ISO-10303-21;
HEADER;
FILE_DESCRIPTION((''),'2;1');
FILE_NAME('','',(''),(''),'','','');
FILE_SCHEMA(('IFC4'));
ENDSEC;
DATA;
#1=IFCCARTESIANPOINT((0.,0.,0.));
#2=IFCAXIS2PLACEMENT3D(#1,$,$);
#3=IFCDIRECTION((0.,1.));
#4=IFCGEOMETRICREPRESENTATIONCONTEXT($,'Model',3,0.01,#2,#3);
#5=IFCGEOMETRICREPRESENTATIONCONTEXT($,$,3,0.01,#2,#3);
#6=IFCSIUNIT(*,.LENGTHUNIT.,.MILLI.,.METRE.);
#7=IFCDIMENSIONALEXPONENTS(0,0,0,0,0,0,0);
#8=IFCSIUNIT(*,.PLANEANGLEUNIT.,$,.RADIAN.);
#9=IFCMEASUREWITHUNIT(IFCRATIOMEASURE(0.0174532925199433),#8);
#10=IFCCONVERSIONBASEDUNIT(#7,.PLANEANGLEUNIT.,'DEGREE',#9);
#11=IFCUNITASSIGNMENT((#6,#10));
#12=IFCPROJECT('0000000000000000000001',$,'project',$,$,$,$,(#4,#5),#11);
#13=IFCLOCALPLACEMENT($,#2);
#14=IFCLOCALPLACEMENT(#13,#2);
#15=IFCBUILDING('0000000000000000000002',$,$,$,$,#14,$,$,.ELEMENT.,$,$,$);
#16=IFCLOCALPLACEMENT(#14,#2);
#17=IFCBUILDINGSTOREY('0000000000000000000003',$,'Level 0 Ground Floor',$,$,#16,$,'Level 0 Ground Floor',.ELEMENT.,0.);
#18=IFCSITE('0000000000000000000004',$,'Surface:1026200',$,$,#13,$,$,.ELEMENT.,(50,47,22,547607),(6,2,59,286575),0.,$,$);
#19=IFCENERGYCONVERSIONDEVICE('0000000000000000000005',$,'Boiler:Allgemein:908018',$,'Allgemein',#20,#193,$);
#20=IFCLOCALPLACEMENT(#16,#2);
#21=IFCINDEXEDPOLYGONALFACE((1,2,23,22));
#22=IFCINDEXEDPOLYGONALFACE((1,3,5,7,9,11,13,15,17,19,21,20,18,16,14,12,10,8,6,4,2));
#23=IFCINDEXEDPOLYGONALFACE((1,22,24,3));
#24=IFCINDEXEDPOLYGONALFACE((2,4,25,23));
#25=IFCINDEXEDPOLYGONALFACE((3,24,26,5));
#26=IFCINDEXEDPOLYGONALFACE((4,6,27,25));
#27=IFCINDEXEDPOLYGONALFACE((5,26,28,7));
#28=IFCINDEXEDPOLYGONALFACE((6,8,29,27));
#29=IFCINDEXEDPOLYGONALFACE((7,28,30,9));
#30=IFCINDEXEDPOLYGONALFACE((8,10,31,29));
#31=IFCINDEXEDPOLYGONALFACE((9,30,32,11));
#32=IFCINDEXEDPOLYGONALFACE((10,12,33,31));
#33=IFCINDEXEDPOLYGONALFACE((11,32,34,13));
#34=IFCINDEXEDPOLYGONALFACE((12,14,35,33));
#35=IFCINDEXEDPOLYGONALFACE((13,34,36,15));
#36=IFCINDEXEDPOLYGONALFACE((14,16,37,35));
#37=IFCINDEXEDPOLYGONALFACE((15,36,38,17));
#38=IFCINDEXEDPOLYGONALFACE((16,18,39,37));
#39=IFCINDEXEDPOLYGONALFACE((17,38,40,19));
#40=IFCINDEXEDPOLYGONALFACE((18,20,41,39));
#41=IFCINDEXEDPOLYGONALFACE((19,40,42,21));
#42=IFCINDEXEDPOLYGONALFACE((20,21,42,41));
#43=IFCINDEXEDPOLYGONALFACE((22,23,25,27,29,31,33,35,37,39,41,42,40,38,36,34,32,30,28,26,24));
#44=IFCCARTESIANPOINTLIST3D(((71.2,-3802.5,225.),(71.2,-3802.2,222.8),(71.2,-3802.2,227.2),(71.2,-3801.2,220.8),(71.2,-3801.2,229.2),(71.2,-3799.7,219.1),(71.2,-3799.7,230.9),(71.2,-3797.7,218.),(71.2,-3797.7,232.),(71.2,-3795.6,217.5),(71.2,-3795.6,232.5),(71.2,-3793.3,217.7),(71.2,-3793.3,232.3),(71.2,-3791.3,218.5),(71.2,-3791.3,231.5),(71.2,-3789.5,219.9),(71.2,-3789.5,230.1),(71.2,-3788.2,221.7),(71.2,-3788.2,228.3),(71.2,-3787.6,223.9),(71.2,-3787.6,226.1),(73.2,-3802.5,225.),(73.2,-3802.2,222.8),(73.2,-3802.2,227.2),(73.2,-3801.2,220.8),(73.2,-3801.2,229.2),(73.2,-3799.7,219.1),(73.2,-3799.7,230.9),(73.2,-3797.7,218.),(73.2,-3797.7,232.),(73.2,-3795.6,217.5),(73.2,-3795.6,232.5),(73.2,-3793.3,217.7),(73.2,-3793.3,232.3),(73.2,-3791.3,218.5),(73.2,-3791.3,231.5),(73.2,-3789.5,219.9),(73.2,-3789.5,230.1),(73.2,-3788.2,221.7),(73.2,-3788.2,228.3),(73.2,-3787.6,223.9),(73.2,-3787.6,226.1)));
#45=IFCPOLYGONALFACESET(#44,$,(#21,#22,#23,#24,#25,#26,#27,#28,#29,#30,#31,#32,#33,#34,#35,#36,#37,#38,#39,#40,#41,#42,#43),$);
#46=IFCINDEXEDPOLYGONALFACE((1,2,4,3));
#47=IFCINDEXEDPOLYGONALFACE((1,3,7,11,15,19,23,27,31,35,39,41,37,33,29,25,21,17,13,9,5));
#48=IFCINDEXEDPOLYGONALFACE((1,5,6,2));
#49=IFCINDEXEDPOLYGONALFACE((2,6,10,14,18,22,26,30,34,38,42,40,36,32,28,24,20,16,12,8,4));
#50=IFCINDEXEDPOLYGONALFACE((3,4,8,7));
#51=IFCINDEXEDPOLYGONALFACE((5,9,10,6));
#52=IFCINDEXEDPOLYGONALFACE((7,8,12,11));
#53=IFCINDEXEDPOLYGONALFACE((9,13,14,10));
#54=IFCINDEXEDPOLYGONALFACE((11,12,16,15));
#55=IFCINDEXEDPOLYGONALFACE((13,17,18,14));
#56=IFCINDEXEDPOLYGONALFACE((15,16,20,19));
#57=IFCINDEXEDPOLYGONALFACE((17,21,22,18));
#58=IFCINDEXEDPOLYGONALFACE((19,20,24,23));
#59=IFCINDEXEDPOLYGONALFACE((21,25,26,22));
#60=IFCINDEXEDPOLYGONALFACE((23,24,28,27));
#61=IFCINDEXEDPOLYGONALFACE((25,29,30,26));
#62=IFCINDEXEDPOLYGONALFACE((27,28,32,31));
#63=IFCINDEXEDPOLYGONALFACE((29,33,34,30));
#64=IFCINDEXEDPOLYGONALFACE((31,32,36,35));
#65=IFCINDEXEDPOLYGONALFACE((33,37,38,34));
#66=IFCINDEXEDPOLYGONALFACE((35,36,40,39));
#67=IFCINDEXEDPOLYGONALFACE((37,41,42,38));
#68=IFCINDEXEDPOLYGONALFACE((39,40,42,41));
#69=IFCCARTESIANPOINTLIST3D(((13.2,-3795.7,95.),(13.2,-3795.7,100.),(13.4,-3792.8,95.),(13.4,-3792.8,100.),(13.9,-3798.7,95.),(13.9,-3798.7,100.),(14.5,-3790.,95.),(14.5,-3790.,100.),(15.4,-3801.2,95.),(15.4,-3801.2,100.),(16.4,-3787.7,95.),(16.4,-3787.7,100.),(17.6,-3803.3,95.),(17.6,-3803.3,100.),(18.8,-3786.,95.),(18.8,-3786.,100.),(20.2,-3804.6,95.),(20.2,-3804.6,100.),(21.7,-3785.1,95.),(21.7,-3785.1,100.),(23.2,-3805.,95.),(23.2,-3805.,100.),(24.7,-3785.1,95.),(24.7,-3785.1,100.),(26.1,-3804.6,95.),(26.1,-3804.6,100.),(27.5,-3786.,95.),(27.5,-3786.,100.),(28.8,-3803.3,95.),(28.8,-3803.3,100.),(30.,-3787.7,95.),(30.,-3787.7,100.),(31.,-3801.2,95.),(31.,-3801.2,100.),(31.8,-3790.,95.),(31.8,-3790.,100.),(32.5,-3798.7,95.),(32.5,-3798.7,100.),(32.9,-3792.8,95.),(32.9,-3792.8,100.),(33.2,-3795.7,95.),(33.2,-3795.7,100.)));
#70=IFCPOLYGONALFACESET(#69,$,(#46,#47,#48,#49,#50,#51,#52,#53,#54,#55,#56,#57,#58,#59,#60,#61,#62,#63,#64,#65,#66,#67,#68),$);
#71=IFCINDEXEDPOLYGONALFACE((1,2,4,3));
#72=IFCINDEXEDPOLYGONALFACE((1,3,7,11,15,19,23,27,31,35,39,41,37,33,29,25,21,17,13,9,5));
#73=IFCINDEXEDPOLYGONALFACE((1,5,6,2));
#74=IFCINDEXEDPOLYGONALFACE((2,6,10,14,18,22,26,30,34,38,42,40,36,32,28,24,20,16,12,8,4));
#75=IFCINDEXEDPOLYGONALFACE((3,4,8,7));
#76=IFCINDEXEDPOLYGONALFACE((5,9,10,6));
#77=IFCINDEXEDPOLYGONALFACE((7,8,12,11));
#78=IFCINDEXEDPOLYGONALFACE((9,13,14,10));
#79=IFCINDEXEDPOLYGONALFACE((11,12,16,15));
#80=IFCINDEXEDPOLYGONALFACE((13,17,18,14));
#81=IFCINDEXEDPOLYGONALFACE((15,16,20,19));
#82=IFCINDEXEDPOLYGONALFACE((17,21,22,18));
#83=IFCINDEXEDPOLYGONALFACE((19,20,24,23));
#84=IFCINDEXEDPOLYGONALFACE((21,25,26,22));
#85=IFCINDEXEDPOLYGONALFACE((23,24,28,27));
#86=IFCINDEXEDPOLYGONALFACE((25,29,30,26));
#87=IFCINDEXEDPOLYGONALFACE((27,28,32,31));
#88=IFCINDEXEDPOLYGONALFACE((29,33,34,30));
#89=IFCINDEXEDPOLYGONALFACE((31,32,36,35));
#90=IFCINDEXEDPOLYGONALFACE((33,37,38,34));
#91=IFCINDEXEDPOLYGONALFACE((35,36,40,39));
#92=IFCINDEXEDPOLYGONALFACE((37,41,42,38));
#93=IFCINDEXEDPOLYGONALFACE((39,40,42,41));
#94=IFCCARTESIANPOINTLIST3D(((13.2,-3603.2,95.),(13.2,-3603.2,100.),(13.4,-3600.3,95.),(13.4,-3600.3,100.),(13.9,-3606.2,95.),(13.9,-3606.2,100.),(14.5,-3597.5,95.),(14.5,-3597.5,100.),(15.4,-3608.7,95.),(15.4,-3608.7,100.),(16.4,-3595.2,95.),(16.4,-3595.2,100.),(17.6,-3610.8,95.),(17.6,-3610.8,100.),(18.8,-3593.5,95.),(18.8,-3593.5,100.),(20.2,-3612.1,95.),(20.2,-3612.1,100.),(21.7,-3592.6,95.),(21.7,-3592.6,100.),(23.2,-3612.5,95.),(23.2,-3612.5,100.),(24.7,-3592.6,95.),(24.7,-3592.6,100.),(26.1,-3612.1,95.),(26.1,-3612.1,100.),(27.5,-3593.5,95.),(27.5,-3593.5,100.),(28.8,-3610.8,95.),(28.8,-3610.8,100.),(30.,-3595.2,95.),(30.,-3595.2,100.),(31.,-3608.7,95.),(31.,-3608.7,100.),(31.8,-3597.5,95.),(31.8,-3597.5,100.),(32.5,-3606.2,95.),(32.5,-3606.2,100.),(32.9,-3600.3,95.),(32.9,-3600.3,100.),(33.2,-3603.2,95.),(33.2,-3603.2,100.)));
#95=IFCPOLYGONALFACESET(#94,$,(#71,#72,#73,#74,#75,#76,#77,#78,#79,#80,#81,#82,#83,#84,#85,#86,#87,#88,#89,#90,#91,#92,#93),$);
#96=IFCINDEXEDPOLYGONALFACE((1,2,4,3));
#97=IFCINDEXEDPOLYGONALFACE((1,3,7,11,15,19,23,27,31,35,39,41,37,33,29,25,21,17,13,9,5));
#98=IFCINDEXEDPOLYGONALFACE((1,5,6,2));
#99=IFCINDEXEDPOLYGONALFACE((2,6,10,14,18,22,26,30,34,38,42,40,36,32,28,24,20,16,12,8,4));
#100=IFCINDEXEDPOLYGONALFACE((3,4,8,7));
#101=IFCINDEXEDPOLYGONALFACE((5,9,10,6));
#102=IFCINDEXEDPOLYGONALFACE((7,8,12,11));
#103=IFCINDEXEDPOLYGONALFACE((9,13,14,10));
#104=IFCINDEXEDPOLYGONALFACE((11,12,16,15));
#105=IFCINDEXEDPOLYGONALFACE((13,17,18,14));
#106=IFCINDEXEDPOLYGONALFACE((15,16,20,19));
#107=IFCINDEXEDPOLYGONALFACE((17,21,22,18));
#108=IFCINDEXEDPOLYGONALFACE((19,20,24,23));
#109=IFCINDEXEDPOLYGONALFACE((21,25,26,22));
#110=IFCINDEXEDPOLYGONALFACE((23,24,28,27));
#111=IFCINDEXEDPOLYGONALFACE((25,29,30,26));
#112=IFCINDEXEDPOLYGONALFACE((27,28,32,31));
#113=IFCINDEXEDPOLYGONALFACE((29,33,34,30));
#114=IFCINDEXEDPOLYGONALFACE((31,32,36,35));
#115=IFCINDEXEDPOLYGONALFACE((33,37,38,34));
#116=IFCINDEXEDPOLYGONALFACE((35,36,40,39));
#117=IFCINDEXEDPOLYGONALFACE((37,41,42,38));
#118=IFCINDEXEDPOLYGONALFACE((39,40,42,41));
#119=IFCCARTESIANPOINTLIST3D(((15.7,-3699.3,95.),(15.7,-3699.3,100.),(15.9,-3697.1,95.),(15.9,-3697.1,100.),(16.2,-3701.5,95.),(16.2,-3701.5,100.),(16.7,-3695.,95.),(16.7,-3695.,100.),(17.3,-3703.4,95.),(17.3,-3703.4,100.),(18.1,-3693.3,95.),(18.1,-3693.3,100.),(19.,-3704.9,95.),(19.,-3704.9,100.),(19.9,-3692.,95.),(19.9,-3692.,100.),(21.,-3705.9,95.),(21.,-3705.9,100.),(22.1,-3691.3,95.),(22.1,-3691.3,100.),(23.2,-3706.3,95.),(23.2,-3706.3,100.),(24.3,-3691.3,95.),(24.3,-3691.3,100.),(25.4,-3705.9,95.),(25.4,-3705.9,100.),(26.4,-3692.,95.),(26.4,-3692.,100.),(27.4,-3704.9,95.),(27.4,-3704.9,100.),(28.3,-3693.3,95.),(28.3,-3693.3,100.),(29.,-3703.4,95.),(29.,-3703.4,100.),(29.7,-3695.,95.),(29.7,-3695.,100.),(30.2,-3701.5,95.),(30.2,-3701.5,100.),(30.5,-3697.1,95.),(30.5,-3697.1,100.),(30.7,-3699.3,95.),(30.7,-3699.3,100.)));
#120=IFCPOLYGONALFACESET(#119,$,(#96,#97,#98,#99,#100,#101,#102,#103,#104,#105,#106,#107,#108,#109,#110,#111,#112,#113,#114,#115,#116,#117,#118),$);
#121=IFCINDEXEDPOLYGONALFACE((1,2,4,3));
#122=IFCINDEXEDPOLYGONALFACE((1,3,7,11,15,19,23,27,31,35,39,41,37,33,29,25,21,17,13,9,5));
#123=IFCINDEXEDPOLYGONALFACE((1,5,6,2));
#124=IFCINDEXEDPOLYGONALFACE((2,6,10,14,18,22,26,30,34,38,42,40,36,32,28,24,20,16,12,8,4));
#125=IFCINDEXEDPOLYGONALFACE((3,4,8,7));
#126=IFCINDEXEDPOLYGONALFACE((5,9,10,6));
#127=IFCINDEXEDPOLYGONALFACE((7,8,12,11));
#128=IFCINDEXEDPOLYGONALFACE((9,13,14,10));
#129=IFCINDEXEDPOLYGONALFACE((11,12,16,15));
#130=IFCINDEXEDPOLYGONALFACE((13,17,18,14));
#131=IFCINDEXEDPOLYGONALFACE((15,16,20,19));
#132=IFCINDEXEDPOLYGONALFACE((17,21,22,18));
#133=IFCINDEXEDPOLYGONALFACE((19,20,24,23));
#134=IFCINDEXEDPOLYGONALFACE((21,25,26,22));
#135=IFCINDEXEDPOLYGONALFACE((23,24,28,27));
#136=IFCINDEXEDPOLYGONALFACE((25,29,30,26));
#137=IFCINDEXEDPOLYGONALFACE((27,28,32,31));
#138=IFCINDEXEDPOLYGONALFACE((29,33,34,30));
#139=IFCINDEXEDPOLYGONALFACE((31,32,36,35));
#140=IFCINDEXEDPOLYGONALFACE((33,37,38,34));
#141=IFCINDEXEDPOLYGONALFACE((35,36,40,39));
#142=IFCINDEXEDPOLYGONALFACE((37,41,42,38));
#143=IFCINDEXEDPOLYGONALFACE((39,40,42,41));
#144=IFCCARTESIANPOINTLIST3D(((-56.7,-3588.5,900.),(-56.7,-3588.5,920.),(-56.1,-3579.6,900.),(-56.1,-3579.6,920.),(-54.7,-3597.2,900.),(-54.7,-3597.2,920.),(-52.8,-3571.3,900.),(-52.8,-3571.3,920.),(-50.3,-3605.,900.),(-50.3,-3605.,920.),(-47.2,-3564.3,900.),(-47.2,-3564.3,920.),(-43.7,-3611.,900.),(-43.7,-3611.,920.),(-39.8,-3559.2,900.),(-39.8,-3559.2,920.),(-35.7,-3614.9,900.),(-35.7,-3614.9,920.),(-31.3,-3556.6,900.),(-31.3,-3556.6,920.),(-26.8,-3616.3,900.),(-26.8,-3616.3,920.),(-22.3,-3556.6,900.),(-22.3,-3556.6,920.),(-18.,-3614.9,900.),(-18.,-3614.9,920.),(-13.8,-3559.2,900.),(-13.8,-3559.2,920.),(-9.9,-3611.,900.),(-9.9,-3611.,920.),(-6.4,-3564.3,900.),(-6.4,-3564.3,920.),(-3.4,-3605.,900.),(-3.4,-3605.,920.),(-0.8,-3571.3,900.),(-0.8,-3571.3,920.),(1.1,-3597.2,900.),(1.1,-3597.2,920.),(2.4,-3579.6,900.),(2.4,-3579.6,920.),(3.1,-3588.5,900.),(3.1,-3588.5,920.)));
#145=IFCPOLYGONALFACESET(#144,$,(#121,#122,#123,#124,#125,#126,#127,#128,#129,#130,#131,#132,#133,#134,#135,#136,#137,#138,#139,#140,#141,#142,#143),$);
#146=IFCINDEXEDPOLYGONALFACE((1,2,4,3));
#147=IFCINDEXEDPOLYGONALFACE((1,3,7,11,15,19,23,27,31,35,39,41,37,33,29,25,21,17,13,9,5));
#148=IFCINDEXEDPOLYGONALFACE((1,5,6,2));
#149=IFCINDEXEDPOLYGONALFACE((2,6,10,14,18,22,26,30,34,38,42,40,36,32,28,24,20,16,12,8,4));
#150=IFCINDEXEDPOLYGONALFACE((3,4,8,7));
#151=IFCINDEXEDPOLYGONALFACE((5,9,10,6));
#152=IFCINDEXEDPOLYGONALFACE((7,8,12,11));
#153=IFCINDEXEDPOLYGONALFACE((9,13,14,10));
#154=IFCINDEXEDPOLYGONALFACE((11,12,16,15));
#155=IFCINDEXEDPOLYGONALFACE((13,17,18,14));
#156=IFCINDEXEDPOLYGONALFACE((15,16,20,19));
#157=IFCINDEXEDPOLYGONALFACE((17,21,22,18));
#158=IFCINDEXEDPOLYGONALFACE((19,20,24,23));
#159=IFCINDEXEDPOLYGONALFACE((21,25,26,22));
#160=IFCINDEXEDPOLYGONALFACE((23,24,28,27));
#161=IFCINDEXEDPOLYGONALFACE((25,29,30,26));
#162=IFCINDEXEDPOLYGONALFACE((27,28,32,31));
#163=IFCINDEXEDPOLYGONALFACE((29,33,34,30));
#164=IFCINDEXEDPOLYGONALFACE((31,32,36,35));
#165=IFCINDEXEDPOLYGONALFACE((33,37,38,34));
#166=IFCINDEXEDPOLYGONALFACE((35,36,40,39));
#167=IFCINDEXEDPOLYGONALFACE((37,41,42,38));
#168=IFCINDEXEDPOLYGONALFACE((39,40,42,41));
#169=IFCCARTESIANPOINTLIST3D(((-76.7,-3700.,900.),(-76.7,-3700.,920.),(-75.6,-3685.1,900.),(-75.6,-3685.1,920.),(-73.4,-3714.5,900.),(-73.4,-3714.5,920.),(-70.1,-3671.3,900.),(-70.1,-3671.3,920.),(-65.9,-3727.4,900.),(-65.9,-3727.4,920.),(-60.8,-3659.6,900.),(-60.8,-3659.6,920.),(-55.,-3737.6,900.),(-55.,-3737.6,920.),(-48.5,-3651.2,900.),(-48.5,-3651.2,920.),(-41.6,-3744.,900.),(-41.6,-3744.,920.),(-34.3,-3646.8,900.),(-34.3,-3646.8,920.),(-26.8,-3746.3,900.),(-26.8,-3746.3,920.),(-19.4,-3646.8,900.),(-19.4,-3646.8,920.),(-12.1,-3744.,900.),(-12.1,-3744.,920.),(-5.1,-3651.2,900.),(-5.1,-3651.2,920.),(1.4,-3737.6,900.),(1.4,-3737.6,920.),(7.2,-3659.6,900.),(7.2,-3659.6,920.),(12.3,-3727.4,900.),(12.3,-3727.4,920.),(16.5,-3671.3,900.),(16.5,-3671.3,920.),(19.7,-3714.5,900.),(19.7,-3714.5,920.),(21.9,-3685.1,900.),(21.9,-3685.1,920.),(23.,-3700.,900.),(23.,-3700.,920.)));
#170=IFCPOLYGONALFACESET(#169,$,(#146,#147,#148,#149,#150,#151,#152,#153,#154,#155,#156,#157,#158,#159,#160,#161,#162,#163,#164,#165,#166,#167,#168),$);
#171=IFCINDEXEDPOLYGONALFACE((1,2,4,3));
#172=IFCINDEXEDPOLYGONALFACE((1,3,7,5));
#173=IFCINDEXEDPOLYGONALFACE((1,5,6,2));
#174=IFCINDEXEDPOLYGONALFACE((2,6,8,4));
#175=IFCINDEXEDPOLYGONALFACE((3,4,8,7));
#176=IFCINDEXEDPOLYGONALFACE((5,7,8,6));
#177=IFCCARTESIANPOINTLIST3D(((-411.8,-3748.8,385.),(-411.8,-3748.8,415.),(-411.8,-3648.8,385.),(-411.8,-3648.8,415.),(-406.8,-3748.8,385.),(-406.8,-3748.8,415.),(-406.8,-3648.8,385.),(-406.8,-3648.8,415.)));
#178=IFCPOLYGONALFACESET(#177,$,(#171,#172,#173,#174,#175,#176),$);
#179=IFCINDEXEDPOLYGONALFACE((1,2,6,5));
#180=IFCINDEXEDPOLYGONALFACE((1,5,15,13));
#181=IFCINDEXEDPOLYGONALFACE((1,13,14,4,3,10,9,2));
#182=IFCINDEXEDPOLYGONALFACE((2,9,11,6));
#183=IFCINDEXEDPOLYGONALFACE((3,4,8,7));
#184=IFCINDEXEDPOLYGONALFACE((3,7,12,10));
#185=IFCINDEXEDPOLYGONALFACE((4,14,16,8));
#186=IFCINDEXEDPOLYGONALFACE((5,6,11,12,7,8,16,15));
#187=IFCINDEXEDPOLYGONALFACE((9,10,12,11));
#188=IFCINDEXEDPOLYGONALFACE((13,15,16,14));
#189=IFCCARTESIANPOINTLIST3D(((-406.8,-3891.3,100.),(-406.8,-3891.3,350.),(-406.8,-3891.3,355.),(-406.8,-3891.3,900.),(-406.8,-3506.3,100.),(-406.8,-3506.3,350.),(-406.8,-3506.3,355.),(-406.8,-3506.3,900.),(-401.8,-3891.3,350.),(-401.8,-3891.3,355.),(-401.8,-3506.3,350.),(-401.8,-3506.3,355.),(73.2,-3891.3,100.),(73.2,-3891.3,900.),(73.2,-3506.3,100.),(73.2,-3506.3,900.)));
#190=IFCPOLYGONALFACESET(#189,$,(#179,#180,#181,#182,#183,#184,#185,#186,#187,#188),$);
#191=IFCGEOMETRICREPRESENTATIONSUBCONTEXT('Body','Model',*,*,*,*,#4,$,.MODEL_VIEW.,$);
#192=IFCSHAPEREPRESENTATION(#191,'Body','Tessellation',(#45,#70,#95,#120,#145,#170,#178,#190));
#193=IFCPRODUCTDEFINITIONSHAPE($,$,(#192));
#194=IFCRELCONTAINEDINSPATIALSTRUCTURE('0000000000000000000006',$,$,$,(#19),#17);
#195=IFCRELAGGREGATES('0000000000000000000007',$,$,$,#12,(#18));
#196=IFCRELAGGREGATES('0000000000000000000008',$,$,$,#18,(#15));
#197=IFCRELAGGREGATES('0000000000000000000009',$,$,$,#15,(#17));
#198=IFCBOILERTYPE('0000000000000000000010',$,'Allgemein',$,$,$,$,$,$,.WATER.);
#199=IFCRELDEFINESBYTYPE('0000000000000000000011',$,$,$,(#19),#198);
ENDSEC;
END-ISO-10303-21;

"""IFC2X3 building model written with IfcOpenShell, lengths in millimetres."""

from ifc_helpers import new_model, entity, si_unit, converted_unit, direction, frame, frame_2d, origin, origin_2d_with_axis, place, context, subcontext, project, spatial, polyline, rectangle, circle, outline, extrude, source, transform, mapped, type_object, type_shapes, element, save


model = new_model("IFC2X3")

# Units and contexts
model_context = context("Model", 3, precision=0.01, world=origin(), true_north=direction((0.0, 1.0)))
context_of_model = context(None, 3, precision=0.01, world=origin(), true_north=direction((0.0, 1.0)))
body_context = subcontext(model_context, "Body", "Model", "MODEL_VIEW")
ifc_project = project(units=[si_unit("LENGTHUNIT", "METRE", prefix="MILLI"), converted_unit("PLANEANGLEUNIT", "DEGREE", entity("IfcRatioMeasure", 0.0174532925199433), si_unit("PLANEANGLEUNIT", "RADIAN"), dimensions=[0, 0, 0, 0, 0, 0, 0])], contexts=[model_context, context_of_model])

# Site, building, storey
site_placement = place(None, origin())
site = spatial("IfcSite", under=ifc_project, at=site_placement, Name="Surface:1026200", CompositionType="ELEMENT", RefLatitude=(50, 47, 22, 547607), RefLongitude=(6, 2, 59, 286575), RefElevation=0.0)
building_placement = place(site_placement, origin())
building = spatial("IfcBuilding", under=site, at=building_placement, CompositionType="ELEMENT")
storey_placement = place(building_placement, origin())
storey = spatial("IfcBuildingStorey", under=building, at=storey_placement, Name="Level 0 Ground Floor", LongName="Level 0 Ground Floor", CompositionType="ELEMENT", Elevation=0.0)

# Energy conversion device
boiler_type = type_object("IfcBoilerType", Name="Allgemein", PredefinedType="WATER")
shared_shape_1 = source(origin(), body_context, "Body", "SweptSolid", [
    extrude(circle(Radius=7.5, at=frame_2d((0.0, 0.0), x_axis=(1.0, 0.0))), frame((96.3, -2.0, 125.0), z_axis=(0.0, 1.0, 0.0), x_axis=(1.0, 0.0, 0.0)), (0.0, 0.0, 1.0), 2.0),
    extrude(circle(Radius=10.0, at=frame_2d((0.0, 0.0), x_axis=(1.0, 0.0))), frame((96.2, -50.0, -5.0)), (0.0, 0.0, 1.0), 5.0),
    extrude(circle(Radius=10.0, at=frame_2d((0.0, 0.0), x_axis=(1.0, 0.0))), frame((-96.3, -50.0, -5.0)), (0.0, 0.0, 1.0), 5.0),
    extrude(circle(Radius=7.5, at=frame_2d((0.0, 0.0), x_axis=(1.0, 0.0))), frame((0.0, -50.0, -5.0)), (0.0, 0.0, 1.0), 5.0),
    extrude(circle(Radius=30.0, at=frame_2d((0.0, 0.0), x_axis=(1.0, 0.0))), frame((-112.5, -100.0, 800.0)), (0.0, 0.0, 1.0), 20.0),
    extrude(circle(Radius=50.0, at=frame_2d((0.0, 0.0), x_axis=(1.0, 0.0))), frame((-2.5, -100.0, 800.0)), (0.0, 0.0, 1.0), 20.0),
    extrude(rectangle(XDim=5.0, YDim=100.0, at=origin_2d_with_axis()), frame((0.0, -482.5, 285.0), z_axis=(0.0, 0.0, 1.0), x_axis=(0.0, 1.0, 0.0)), (0.0, 0.0, 1.0), 30.0),
    extrude(outline(polyline([(-358.8, -473.8), (121.2, -473.8), (121.2, 71.2), (116.3, 71.2), (116.3, 76.3), (121.2, 76.3), (121.2, 326.2), (-358.8, 326.2), (-358.8, -473.8)])), frame((-192.5, -358.8, 326.2), z_axis=(1.0, 0.0, 0.0), x_axis=(0.0, -1.0, 0.0)), (0.0, 0.0, 1.0), 385.0),
])
type_shapes(boiler_type, [shared_shape_1])
energy_conversion_device_placement = place(storey_placement, frame((73.2, -3698.8, 100.0), z_axis=(0.0, 0.0, 1.0), x_axis=(0.0, -1.0, 0.0)))
element("IfcEnergyConversionDevice", 1, at=energy_conversion_device_placement, inside=storey, type_object=boiler_type, Name="Boiler:Allgemein:908018", ObjectType="Allgemein", context=body_context, shape_type="MappedRepresentation", body=[
    mapped(shared_shape_1, transform((0.0, 0.0, 0.0), scale=1.0)),
])

save(model, "model.ifc")
